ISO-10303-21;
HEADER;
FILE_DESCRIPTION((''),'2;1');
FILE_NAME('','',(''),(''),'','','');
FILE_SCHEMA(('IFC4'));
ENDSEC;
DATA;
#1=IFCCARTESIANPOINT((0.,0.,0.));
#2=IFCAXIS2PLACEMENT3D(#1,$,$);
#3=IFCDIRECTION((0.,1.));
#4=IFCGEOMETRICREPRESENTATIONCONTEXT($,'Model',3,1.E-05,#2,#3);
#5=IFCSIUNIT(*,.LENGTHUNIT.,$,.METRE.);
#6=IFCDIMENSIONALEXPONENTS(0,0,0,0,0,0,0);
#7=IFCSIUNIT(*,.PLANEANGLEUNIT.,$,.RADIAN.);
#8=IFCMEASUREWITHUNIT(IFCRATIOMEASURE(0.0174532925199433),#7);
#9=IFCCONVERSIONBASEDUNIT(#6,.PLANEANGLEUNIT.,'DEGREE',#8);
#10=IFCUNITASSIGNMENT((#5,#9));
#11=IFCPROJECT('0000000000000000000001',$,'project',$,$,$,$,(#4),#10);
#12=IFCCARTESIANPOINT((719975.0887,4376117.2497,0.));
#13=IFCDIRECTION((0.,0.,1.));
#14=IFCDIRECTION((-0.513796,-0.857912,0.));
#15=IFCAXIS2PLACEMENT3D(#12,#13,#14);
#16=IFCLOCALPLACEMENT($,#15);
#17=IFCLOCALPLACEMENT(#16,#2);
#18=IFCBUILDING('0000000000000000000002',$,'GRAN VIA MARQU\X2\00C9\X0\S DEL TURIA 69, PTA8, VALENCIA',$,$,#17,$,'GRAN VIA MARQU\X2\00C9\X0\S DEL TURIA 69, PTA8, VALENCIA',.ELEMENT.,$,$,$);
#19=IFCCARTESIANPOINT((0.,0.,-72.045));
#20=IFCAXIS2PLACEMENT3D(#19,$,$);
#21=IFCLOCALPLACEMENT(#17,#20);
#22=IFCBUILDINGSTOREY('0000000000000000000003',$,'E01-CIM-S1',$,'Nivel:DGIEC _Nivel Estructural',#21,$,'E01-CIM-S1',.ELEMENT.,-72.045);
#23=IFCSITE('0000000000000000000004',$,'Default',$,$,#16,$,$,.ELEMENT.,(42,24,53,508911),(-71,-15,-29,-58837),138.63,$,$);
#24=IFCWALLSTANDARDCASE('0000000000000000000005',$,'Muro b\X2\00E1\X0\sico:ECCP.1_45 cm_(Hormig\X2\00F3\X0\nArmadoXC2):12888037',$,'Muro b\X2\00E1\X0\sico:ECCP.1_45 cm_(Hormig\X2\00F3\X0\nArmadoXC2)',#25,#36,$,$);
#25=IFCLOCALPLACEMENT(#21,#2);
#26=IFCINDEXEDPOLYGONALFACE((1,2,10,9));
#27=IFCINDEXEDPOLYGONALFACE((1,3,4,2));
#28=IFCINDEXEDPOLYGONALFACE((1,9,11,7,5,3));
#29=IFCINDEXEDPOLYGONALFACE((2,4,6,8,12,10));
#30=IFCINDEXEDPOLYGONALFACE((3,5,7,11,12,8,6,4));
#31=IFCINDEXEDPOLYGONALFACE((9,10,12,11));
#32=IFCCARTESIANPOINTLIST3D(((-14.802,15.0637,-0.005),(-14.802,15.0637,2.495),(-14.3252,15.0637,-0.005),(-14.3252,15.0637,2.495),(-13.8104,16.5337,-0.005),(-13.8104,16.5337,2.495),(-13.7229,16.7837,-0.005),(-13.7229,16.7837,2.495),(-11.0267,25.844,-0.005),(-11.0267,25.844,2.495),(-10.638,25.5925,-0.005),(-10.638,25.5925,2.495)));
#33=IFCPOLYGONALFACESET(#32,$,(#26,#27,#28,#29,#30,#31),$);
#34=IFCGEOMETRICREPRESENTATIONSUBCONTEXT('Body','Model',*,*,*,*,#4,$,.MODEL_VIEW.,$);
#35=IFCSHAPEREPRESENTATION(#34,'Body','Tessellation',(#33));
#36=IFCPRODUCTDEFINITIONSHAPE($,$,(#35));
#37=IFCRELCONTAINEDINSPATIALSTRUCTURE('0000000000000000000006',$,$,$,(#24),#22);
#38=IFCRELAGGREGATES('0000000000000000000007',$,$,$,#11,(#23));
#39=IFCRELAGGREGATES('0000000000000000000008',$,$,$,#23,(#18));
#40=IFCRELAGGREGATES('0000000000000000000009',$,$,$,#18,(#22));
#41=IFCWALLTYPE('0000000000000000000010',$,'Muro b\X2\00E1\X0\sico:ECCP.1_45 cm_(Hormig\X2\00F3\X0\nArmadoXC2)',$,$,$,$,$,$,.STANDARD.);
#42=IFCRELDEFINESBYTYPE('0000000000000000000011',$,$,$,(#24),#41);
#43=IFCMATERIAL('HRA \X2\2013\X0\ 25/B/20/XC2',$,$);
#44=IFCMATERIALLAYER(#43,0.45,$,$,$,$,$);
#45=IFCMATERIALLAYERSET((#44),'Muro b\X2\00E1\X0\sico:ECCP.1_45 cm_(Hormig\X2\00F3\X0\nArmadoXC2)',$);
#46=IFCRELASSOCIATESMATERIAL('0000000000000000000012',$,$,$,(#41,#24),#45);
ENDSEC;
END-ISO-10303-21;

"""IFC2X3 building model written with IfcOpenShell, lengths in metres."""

from ifc_helpers import new_model, entity, si_unit, converted_unit, direction, frame, origin, place, context, subcontext, project, spatial, polyline, outline, extrude, material, layer, layer_set, layer_usage, type_object, element, save


model = new_model("IFC2X3")

# Units and contexts
model_context = context("Model", 3, precision=1e-05, world=origin(), true_north=direction((0.0, 1.0)))
body_context = subcontext(model_context, "Body", "Model", "MODEL_VIEW")
ifc_project = project(units=[si_unit("LENGTHUNIT", "METRE"), converted_unit("PLANEANGLEUNIT", "DEGREE", entity("IfcRatioMeasure", 0.0174532925199433), si_unit("PLANEANGLEUNIT", "RADIAN"), dimensions=[0, 0, 0, 0, 0, 0, 0])], contexts=[model_context])

# Site, building, storey
site_placement = place(None, frame((719975.0887, 4376117.2497, 0.0), z_axis=(0.0, 0.0, 1.0), x_axis=(-0.513796, -0.857912, 0.0)))
site = spatial("IfcSite", under=ifc_project, at=site_placement, Name="Default", CompositionType="ELEMENT", RefLatitude=(42, 24, 53, 508911), RefLongitude=(-71, -15, -29, -58837), RefElevation=138.63)
building_placement = place(site_placement, origin())
building = spatial("IfcBuilding", under=site, at=building_placement, Name="GRAN VIA MARQUÉS DEL TURIA 69, PTA8, VALENCIA", LongName="GRAN VIA MARQUÉS DEL TURIA 69, PTA8, VALENCIA", CompositionType="ELEMENT")
storey_placement = place(building_placement, frame((0.0, 0.0, -72.045)))
storey = spatial("IfcBuildingStorey", under=building, at=storey_placement, Name="E01-CIM-S1", ObjectType="Nivel:DGIEC _Nivel Estructural", LongName="E01-CIM-S1", CompositionType="ELEMENT", Elevation=-72.045)

# Shared definitions
ifc_material = material(Name="HRA – 25/B/20/XC2")

# Wall
ifc_layer_1 = layer(ifc_material, 0.45)
ifc_layer_set_1 = layer_set([ifc_layer_1], Name="Muro básico:ECCP.1_45 cm_(HormigónArmadoXC2)")
wall_type_1 = type_object("IfcWallType", Name="Muro básico:ECCP.1_45 cm_(HormigónArmadoXC2)", PredefinedType="STANDARD", material=ifc_layer_set_1)
ifc_layer_usage_1 = layer_usage(ifc_layer_set_1, "AXIS2", "NEGATIVE", 0.225)
wall_1_placement = place(storey_placement, frame((-14.5897, 14.9894, -0.005), z_axis=(0.0, 0.0, 1.0), x_axis=(0.330527, 0.943797, 0.0)))
element("IfcWallStandardCase", 1, at=wall_1_placement, inside=storey, type_object=wall_type_1, material=ifc_layer_usage_1, Name="Muro básico:ECCP.1_45 cm_(HormigónArmadoXC2):12888037", ObjectType="Muro básico:ECCP.1_45 cm_(HormigónArmadoXC2)", context=body_context, shape_type="SweptSolid", body=[
    extrude(outline(polyline([(11.3133, -0.225), (11.4222, 0.225), (0.0, 0.225), (0.1576, -0.225), (1.7151, -0.225), (1.98, -0.225), (11.3133, -0.225)])), origin(), (0.0, 0.0, 1.0), 2.5),
])

save(model, "model.ifc")
